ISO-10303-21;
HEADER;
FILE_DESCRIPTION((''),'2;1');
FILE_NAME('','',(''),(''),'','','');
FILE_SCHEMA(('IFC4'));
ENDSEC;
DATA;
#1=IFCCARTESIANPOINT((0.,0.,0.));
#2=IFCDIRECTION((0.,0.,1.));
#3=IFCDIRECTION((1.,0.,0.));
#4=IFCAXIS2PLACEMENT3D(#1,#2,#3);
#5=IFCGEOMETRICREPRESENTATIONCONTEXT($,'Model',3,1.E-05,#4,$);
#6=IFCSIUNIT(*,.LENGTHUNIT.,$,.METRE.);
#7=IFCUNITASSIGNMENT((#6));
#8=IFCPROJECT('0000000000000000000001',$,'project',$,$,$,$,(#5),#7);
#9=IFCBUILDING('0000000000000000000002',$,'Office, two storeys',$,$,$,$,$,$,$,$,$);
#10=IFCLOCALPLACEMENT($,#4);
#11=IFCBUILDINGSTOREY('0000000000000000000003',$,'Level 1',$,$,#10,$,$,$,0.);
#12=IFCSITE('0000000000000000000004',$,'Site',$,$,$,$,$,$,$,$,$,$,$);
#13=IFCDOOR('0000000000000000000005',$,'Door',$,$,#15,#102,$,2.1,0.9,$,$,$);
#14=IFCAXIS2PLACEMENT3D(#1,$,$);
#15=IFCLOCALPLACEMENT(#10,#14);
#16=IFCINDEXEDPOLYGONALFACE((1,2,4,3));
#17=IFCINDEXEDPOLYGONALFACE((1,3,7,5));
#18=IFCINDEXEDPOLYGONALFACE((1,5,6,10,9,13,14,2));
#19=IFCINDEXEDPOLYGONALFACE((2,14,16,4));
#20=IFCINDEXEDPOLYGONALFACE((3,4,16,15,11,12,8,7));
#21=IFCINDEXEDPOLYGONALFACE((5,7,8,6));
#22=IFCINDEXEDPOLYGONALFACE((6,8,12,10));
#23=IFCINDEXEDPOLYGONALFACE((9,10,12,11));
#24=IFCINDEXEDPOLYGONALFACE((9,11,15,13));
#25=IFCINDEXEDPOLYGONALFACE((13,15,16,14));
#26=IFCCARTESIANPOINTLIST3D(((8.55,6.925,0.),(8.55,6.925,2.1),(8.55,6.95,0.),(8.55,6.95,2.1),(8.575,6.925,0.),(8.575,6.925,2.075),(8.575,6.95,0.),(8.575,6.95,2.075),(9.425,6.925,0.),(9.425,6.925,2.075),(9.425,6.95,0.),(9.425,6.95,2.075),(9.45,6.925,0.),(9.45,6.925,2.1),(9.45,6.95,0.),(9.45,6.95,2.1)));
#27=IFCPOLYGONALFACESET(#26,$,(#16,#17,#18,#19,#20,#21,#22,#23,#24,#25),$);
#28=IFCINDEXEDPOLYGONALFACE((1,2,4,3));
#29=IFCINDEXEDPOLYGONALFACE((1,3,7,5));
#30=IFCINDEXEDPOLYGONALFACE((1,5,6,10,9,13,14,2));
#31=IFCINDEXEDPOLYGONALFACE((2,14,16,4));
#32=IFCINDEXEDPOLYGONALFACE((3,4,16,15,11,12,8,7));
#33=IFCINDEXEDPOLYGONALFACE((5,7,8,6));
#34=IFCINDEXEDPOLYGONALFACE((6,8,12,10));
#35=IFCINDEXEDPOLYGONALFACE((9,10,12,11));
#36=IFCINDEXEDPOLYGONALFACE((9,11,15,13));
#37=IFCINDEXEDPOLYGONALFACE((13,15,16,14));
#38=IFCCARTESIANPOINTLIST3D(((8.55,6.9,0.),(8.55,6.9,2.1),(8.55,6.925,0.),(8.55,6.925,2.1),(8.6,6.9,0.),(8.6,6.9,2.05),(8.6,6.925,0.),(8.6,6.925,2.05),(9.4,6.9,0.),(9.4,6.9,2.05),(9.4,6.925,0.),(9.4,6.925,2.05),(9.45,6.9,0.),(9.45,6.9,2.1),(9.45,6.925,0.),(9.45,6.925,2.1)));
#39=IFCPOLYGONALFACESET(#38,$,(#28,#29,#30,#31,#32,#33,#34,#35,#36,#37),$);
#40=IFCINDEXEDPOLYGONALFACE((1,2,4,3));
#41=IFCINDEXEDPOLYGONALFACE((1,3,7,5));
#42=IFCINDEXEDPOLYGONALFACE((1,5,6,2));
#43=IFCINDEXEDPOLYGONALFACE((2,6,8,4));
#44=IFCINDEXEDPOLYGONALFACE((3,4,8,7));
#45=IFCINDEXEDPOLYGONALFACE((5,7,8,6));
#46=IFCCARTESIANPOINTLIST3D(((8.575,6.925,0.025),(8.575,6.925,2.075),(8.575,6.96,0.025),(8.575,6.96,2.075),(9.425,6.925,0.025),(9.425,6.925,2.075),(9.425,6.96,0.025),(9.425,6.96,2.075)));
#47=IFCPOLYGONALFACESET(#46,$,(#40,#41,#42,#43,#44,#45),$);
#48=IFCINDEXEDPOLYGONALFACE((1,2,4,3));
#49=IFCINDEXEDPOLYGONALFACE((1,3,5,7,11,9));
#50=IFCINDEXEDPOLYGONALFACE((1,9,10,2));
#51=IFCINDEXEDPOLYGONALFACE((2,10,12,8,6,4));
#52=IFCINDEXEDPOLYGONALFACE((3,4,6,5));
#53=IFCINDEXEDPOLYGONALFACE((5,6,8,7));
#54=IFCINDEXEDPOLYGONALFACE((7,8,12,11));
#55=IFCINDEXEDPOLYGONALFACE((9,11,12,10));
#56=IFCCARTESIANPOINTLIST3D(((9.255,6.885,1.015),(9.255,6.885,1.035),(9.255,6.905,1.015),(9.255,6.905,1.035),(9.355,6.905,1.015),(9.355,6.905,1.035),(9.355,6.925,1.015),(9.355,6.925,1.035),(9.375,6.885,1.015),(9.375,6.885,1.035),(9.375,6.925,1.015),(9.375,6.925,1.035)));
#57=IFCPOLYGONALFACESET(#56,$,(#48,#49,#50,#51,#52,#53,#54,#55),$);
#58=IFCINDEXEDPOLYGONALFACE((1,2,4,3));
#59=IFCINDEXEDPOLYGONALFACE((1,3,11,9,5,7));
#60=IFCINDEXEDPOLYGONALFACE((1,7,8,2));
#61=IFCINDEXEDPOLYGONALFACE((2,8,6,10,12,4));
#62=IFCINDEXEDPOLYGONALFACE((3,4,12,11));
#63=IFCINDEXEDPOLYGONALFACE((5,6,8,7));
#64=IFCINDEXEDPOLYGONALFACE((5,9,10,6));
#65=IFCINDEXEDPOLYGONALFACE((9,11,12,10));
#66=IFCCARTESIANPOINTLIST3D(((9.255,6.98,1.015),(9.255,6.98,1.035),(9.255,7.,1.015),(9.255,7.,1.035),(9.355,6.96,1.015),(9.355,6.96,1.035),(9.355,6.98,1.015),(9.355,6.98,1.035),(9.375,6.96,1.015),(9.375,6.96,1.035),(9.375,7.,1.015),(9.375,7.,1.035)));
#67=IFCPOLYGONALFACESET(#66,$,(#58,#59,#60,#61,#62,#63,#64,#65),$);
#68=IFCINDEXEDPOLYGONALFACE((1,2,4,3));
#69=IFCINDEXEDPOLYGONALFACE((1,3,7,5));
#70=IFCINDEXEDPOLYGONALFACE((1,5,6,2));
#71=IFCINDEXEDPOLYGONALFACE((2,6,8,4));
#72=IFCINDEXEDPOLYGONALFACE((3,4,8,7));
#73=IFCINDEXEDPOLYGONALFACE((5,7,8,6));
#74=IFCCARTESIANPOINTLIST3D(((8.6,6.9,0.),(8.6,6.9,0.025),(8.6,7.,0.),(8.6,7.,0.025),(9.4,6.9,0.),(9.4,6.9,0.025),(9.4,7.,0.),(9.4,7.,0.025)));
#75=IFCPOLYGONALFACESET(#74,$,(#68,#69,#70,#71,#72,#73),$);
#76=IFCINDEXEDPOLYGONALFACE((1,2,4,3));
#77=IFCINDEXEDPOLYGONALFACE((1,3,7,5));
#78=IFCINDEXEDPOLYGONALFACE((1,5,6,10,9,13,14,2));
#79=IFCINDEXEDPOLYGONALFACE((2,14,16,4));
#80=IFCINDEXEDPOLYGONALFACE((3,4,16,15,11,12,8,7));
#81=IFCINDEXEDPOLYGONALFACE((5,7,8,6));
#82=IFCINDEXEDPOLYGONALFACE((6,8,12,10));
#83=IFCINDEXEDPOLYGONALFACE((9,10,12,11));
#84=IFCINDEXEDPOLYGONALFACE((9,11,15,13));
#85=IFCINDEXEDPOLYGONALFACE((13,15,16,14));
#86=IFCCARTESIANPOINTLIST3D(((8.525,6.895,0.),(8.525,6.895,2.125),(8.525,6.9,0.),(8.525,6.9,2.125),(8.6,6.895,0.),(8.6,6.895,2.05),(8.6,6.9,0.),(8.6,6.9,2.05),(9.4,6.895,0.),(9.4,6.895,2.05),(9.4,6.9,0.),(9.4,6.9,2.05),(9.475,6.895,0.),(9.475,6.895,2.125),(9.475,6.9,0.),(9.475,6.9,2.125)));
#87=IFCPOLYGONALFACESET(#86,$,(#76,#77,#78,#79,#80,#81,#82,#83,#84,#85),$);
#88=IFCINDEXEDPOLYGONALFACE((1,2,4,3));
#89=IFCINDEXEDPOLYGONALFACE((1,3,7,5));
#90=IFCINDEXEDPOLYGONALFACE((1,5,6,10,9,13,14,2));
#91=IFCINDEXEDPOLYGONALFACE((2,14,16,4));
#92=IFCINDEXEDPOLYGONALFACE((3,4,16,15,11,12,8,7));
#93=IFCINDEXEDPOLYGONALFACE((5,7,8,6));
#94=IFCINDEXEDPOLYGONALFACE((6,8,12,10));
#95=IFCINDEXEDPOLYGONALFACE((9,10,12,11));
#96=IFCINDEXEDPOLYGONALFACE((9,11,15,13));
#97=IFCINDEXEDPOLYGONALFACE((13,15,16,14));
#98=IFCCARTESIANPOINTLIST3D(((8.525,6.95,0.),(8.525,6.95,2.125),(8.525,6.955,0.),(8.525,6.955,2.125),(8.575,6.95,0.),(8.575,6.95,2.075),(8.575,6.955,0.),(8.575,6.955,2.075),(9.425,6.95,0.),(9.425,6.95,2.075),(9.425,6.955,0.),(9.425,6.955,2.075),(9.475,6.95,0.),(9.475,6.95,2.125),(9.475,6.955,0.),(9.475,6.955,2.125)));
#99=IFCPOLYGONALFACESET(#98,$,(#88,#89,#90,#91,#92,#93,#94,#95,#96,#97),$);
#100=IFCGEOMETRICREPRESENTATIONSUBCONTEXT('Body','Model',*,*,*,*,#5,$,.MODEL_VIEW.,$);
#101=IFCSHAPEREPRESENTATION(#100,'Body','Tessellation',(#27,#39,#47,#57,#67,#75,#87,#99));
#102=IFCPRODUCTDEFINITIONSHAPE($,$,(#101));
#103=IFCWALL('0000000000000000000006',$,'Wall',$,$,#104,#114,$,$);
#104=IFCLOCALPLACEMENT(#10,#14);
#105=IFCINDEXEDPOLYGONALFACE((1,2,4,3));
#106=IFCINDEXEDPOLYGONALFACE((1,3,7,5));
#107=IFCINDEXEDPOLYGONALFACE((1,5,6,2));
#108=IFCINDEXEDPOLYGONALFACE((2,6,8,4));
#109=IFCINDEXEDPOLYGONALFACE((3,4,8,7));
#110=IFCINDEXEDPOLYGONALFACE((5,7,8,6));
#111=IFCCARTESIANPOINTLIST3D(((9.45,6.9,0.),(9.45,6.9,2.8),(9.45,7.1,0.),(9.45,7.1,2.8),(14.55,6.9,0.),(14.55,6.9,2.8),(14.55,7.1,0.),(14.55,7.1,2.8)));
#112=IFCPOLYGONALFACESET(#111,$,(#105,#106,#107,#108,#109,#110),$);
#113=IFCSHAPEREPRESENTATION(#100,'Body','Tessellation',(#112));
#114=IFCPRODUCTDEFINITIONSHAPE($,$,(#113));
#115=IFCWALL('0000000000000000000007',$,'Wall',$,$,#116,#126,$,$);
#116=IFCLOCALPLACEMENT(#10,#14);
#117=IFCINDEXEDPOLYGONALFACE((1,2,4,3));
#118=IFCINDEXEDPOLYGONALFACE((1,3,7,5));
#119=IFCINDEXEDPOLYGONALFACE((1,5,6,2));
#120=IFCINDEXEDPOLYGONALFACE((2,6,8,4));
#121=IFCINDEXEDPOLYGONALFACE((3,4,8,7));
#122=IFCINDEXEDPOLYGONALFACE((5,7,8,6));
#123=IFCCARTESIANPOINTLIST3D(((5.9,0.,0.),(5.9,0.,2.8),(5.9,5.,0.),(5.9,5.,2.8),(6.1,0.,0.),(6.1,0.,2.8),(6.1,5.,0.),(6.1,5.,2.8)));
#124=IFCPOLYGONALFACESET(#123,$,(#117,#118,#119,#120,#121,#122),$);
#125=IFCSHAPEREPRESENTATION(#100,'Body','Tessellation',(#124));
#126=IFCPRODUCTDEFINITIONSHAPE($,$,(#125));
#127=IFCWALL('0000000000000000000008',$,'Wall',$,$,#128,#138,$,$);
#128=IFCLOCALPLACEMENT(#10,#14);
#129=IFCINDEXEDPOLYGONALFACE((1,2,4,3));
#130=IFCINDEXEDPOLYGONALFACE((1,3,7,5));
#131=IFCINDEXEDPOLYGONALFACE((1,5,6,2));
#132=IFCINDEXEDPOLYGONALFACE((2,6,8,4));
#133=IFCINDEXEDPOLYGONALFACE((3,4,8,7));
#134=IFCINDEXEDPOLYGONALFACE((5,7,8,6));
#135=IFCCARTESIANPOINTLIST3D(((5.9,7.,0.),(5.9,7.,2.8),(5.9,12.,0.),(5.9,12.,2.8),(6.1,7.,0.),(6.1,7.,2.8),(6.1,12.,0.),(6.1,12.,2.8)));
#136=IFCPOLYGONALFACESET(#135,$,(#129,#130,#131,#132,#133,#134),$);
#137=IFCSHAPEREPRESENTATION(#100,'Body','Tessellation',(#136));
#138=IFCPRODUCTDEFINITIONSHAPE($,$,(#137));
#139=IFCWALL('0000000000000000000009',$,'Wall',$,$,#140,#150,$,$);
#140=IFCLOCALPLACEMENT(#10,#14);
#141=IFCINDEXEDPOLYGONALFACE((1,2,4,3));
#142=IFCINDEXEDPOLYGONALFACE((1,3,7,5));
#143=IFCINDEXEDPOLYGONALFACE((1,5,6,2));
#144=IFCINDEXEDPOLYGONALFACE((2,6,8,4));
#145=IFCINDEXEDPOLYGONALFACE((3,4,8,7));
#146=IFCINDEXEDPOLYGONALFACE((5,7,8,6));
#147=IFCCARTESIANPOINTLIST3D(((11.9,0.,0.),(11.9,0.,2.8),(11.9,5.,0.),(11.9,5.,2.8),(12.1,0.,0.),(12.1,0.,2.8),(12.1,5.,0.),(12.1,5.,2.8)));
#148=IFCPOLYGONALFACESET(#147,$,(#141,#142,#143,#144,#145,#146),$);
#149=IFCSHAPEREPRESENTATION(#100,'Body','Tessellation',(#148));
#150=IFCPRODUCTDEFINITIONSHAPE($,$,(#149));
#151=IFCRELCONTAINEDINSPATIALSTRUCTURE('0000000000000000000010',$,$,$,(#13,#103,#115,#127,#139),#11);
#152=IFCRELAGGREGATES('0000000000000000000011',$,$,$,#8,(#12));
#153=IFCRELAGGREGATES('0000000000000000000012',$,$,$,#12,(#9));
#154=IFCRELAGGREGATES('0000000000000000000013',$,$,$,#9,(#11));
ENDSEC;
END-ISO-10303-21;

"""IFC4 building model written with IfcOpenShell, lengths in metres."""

from ifc_helpers import new_model, si_unit, frame, origin_with_axes, place, context, subcontext, project, spatial, line, indexed_curve, outline, extrude, element, save


model = new_model("IFC4")

# Units and contexts
model_context = context("Model", 3, precision=1e-05, world=origin_with_axes())
body_context = subcontext(model_context, "Body", "Model", "MODEL_VIEW")
ifc_project = project(units=[si_unit("LENGTHUNIT", "METRE")], contexts=[model_context])

# Site, building, storey
site = spatial("IfcSite", under=ifc_project, Name="Site")
building = spatial("IfcBuilding", under=site, Name="Office, two storeys")
storey_placement = place(None, origin_with_axes())
storey = spatial("IfcBuildingStorey", under=building, at=storey_placement, Name="Level 1", Elevation=0.0)

# Door
door_1_placement = place(storey_placement, frame((8.55, 6.9, 0.0), z_axis=(0.0, 0.0, 1.0), x_axis=(1.0, 0.0, 0.0)))
element("IfcDoor", 1, at=door_1_placement, inside=storey, Name="Door", OverallHeight=2.1, OverallWidth=0.9, context=body_context, shape_type="SweptSolid", body=[
    extrude(outline(indexed_curve([(0.0, 0.0), (0.0, 2.1), (0.9, 2.1), (0.9, 0.0), (0.875, 0.0), (0.875, 2.075), (0.025, 2.075), (0.025, 0.0)], segments=[line(1, 2, 3, 4, 5, 6, 7, 8, 1)])), frame((0.0, 0.025, 0.0), z_axis=(0.0, -1.0, 0.0), x_axis=(1.0, 0.0, 0.0)), (0.0, 0.0, -1.0), 0.025),
    extrude(outline(indexed_curve([(0.0, 0.0), (0.0, 2.1), (0.9, 2.1), (0.9, 0.0), (0.85, 0.0), (0.85, 2.05), (0.05, 2.05), (0.05, 0.0)], segments=[line(1, 2, 3, 4, 5, 6, 7, 8, 1)])), frame((0.0, 0.0, 0.0), z_axis=(0.0, -1.0, 0.0), x_axis=(1.0, 0.0, 0.0)), (0.0, 0.0, -1.0), 0.025),
    extrude(outline(indexed_curve([(0.0, 0.0), (0.85, 0.0), (0.85, 0.035), (0.0, 0.035)], segments=[line(1, 2, 3, 4, 1)])), frame((0.025, 0.025, 0.025), z_axis=(0.0, 0.0, 1.0), x_axis=(1.0, 0.0, 0.0)), (0.0, 0.0, 1.0), 2.05),
    extrude(outline(indexed_curve([(0.0, 0.0), (0.0, -0.04), (-0.12, -0.04), (-0.12, -0.02), (-0.02, -0.02), (-0.02, 0.0)], segments=[line(1, 2, 3, 4, 5, 6, 1)])), frame((0.825, 0.025, 1.015), z_axis=(0.0, 0.0, 1.0), x_axis=(1.0, 0.0, 0.0)), (0.0, 0.0, 1.0), 0.02),
    extrude(outline(indexed_curve([(0.0, 0.0), (0.0, 0.04), (-0.12, 0.04), (-0.12, 0.02), (-0.02, 0.02), (-0.02, 0.0)], segments=[line(1, 2, 3, 4, 5, 6, 1)])), frame((0.825, 0.06, 1.015), z_axis=(0.0, 0.0, 1.0), x_axis=(1.0, 0.0, 0.0)), (0.0, 0.0, 1.0), 0.02),
    extrude(outline(indexed_curve([(0.0, 0.0), (0.8, 0.0), (0.8, 0.1), (0.0, 0.1)], segments=[line(1, 2, 3, 4, 1)])), frame((0.05, 0.0, 0.0), z_axis=(0.0, 0.0, 1.0), x_axis=(1.0, 0.0, 0.0)), (0.0, 0.0, 1.0), 0.025),
    extrude(outline(indexed_curve([(0.0, 0.0), (0.0, 2.125), (0.95, 2.125), (0.95, 0.0), (0.875, 0.0), (0.875, 2.05), (0.075, 2.05), (0.075, 0.0)], segments=[line(1, 2, 3, 4, 5, 6, 7, 8, 1)])), frame((-0.025, -0.005, 0.0), z_axis=(0.0, -1.0, 0.0), x_axis=(1.0, 0.0, 0.0)), (0.0, 0.0, -1.0), 0.005),
    extrude(outline(indexed_curve([(0.0, 0.0), (0.0, 2.125), (0.95, 2.125), (0.95, 0.0), (0.9, 0.0), (0.9, 2.075), (0.05, 2.075), (0.05, 0.0)], segments=[line(1, 2, 3, 4, 5, 6, 7, 8, 1)])), frame((-0.025, 0.05, 0.0), z_axis=(0.0, -1.0, 0.0), x_axis=(1.0, 0.0, 0.0)), (0.0, 0.0, -1.0), 0.005),
])

# Walls
wall_1_placement = place(storey_placement, frame((9.45, 7.0, 0.0), z_axis=(0.0, 0.0, 1.0), x_axis=(1.0, 0.0, 0.0)))
element("IfcWall", 2, at=wall_1_placement, inside=storey, Name="Wall", context=body_context, shape_type="SweptSolid", body=[
    extrude(outline(indexed_curve([(0.0, 0.0), (0.0, 0.2), (5.1, 0.2), (5.1, 0.0), (0.0, 0.0)], self_intersect=False)), frame((0.0, -0.1, 0.0), z_axis=(0.0, 0.0, 1.0), x_axis=(1.0, 0.0, 0.0)), (0.0, 0.0, 1.0), 2.8),
])
for number, where, z_axis, x_axis, name in (
    (3, (6.0, 0.0, 0.0), (0.0, 0.0, 1.0), (0.0, 1.0, 0.0), "Wall"),
    (4, (6.0, 7.0, 0.0), (0.0, 0.0, 1.0), (0.0, 1.0, 0.0), "Wall"),
    (5, (12.0, 0.0, 0.0), (0.0, 0.0, 1.0), (0.0, 1.0, 0.0), "Wall"),
):
    element("IfcWall", number, at=place(storey_placement, frame(where, z_axis=z_axis, x_axis=x_axis)), inside=storey, Name=name, context=body_context, shape_type="SweptSolid", body=[
        extrude(outline(indexed_curve([(0.0, 0.0), (0.0, 0.2), (5.0, 0.2), (5.0, 0.0), (0.0, 0.0)], self_intersect=False)), frame((0.0, -0.1, 0.0), z_axis=(0.0, 0.0, 1.0), x_axis=(1.0, 0.0, 0.0)), (0.0, 0.0, 1.0), 2.8),
    ])

save(model, "model.ifc")
